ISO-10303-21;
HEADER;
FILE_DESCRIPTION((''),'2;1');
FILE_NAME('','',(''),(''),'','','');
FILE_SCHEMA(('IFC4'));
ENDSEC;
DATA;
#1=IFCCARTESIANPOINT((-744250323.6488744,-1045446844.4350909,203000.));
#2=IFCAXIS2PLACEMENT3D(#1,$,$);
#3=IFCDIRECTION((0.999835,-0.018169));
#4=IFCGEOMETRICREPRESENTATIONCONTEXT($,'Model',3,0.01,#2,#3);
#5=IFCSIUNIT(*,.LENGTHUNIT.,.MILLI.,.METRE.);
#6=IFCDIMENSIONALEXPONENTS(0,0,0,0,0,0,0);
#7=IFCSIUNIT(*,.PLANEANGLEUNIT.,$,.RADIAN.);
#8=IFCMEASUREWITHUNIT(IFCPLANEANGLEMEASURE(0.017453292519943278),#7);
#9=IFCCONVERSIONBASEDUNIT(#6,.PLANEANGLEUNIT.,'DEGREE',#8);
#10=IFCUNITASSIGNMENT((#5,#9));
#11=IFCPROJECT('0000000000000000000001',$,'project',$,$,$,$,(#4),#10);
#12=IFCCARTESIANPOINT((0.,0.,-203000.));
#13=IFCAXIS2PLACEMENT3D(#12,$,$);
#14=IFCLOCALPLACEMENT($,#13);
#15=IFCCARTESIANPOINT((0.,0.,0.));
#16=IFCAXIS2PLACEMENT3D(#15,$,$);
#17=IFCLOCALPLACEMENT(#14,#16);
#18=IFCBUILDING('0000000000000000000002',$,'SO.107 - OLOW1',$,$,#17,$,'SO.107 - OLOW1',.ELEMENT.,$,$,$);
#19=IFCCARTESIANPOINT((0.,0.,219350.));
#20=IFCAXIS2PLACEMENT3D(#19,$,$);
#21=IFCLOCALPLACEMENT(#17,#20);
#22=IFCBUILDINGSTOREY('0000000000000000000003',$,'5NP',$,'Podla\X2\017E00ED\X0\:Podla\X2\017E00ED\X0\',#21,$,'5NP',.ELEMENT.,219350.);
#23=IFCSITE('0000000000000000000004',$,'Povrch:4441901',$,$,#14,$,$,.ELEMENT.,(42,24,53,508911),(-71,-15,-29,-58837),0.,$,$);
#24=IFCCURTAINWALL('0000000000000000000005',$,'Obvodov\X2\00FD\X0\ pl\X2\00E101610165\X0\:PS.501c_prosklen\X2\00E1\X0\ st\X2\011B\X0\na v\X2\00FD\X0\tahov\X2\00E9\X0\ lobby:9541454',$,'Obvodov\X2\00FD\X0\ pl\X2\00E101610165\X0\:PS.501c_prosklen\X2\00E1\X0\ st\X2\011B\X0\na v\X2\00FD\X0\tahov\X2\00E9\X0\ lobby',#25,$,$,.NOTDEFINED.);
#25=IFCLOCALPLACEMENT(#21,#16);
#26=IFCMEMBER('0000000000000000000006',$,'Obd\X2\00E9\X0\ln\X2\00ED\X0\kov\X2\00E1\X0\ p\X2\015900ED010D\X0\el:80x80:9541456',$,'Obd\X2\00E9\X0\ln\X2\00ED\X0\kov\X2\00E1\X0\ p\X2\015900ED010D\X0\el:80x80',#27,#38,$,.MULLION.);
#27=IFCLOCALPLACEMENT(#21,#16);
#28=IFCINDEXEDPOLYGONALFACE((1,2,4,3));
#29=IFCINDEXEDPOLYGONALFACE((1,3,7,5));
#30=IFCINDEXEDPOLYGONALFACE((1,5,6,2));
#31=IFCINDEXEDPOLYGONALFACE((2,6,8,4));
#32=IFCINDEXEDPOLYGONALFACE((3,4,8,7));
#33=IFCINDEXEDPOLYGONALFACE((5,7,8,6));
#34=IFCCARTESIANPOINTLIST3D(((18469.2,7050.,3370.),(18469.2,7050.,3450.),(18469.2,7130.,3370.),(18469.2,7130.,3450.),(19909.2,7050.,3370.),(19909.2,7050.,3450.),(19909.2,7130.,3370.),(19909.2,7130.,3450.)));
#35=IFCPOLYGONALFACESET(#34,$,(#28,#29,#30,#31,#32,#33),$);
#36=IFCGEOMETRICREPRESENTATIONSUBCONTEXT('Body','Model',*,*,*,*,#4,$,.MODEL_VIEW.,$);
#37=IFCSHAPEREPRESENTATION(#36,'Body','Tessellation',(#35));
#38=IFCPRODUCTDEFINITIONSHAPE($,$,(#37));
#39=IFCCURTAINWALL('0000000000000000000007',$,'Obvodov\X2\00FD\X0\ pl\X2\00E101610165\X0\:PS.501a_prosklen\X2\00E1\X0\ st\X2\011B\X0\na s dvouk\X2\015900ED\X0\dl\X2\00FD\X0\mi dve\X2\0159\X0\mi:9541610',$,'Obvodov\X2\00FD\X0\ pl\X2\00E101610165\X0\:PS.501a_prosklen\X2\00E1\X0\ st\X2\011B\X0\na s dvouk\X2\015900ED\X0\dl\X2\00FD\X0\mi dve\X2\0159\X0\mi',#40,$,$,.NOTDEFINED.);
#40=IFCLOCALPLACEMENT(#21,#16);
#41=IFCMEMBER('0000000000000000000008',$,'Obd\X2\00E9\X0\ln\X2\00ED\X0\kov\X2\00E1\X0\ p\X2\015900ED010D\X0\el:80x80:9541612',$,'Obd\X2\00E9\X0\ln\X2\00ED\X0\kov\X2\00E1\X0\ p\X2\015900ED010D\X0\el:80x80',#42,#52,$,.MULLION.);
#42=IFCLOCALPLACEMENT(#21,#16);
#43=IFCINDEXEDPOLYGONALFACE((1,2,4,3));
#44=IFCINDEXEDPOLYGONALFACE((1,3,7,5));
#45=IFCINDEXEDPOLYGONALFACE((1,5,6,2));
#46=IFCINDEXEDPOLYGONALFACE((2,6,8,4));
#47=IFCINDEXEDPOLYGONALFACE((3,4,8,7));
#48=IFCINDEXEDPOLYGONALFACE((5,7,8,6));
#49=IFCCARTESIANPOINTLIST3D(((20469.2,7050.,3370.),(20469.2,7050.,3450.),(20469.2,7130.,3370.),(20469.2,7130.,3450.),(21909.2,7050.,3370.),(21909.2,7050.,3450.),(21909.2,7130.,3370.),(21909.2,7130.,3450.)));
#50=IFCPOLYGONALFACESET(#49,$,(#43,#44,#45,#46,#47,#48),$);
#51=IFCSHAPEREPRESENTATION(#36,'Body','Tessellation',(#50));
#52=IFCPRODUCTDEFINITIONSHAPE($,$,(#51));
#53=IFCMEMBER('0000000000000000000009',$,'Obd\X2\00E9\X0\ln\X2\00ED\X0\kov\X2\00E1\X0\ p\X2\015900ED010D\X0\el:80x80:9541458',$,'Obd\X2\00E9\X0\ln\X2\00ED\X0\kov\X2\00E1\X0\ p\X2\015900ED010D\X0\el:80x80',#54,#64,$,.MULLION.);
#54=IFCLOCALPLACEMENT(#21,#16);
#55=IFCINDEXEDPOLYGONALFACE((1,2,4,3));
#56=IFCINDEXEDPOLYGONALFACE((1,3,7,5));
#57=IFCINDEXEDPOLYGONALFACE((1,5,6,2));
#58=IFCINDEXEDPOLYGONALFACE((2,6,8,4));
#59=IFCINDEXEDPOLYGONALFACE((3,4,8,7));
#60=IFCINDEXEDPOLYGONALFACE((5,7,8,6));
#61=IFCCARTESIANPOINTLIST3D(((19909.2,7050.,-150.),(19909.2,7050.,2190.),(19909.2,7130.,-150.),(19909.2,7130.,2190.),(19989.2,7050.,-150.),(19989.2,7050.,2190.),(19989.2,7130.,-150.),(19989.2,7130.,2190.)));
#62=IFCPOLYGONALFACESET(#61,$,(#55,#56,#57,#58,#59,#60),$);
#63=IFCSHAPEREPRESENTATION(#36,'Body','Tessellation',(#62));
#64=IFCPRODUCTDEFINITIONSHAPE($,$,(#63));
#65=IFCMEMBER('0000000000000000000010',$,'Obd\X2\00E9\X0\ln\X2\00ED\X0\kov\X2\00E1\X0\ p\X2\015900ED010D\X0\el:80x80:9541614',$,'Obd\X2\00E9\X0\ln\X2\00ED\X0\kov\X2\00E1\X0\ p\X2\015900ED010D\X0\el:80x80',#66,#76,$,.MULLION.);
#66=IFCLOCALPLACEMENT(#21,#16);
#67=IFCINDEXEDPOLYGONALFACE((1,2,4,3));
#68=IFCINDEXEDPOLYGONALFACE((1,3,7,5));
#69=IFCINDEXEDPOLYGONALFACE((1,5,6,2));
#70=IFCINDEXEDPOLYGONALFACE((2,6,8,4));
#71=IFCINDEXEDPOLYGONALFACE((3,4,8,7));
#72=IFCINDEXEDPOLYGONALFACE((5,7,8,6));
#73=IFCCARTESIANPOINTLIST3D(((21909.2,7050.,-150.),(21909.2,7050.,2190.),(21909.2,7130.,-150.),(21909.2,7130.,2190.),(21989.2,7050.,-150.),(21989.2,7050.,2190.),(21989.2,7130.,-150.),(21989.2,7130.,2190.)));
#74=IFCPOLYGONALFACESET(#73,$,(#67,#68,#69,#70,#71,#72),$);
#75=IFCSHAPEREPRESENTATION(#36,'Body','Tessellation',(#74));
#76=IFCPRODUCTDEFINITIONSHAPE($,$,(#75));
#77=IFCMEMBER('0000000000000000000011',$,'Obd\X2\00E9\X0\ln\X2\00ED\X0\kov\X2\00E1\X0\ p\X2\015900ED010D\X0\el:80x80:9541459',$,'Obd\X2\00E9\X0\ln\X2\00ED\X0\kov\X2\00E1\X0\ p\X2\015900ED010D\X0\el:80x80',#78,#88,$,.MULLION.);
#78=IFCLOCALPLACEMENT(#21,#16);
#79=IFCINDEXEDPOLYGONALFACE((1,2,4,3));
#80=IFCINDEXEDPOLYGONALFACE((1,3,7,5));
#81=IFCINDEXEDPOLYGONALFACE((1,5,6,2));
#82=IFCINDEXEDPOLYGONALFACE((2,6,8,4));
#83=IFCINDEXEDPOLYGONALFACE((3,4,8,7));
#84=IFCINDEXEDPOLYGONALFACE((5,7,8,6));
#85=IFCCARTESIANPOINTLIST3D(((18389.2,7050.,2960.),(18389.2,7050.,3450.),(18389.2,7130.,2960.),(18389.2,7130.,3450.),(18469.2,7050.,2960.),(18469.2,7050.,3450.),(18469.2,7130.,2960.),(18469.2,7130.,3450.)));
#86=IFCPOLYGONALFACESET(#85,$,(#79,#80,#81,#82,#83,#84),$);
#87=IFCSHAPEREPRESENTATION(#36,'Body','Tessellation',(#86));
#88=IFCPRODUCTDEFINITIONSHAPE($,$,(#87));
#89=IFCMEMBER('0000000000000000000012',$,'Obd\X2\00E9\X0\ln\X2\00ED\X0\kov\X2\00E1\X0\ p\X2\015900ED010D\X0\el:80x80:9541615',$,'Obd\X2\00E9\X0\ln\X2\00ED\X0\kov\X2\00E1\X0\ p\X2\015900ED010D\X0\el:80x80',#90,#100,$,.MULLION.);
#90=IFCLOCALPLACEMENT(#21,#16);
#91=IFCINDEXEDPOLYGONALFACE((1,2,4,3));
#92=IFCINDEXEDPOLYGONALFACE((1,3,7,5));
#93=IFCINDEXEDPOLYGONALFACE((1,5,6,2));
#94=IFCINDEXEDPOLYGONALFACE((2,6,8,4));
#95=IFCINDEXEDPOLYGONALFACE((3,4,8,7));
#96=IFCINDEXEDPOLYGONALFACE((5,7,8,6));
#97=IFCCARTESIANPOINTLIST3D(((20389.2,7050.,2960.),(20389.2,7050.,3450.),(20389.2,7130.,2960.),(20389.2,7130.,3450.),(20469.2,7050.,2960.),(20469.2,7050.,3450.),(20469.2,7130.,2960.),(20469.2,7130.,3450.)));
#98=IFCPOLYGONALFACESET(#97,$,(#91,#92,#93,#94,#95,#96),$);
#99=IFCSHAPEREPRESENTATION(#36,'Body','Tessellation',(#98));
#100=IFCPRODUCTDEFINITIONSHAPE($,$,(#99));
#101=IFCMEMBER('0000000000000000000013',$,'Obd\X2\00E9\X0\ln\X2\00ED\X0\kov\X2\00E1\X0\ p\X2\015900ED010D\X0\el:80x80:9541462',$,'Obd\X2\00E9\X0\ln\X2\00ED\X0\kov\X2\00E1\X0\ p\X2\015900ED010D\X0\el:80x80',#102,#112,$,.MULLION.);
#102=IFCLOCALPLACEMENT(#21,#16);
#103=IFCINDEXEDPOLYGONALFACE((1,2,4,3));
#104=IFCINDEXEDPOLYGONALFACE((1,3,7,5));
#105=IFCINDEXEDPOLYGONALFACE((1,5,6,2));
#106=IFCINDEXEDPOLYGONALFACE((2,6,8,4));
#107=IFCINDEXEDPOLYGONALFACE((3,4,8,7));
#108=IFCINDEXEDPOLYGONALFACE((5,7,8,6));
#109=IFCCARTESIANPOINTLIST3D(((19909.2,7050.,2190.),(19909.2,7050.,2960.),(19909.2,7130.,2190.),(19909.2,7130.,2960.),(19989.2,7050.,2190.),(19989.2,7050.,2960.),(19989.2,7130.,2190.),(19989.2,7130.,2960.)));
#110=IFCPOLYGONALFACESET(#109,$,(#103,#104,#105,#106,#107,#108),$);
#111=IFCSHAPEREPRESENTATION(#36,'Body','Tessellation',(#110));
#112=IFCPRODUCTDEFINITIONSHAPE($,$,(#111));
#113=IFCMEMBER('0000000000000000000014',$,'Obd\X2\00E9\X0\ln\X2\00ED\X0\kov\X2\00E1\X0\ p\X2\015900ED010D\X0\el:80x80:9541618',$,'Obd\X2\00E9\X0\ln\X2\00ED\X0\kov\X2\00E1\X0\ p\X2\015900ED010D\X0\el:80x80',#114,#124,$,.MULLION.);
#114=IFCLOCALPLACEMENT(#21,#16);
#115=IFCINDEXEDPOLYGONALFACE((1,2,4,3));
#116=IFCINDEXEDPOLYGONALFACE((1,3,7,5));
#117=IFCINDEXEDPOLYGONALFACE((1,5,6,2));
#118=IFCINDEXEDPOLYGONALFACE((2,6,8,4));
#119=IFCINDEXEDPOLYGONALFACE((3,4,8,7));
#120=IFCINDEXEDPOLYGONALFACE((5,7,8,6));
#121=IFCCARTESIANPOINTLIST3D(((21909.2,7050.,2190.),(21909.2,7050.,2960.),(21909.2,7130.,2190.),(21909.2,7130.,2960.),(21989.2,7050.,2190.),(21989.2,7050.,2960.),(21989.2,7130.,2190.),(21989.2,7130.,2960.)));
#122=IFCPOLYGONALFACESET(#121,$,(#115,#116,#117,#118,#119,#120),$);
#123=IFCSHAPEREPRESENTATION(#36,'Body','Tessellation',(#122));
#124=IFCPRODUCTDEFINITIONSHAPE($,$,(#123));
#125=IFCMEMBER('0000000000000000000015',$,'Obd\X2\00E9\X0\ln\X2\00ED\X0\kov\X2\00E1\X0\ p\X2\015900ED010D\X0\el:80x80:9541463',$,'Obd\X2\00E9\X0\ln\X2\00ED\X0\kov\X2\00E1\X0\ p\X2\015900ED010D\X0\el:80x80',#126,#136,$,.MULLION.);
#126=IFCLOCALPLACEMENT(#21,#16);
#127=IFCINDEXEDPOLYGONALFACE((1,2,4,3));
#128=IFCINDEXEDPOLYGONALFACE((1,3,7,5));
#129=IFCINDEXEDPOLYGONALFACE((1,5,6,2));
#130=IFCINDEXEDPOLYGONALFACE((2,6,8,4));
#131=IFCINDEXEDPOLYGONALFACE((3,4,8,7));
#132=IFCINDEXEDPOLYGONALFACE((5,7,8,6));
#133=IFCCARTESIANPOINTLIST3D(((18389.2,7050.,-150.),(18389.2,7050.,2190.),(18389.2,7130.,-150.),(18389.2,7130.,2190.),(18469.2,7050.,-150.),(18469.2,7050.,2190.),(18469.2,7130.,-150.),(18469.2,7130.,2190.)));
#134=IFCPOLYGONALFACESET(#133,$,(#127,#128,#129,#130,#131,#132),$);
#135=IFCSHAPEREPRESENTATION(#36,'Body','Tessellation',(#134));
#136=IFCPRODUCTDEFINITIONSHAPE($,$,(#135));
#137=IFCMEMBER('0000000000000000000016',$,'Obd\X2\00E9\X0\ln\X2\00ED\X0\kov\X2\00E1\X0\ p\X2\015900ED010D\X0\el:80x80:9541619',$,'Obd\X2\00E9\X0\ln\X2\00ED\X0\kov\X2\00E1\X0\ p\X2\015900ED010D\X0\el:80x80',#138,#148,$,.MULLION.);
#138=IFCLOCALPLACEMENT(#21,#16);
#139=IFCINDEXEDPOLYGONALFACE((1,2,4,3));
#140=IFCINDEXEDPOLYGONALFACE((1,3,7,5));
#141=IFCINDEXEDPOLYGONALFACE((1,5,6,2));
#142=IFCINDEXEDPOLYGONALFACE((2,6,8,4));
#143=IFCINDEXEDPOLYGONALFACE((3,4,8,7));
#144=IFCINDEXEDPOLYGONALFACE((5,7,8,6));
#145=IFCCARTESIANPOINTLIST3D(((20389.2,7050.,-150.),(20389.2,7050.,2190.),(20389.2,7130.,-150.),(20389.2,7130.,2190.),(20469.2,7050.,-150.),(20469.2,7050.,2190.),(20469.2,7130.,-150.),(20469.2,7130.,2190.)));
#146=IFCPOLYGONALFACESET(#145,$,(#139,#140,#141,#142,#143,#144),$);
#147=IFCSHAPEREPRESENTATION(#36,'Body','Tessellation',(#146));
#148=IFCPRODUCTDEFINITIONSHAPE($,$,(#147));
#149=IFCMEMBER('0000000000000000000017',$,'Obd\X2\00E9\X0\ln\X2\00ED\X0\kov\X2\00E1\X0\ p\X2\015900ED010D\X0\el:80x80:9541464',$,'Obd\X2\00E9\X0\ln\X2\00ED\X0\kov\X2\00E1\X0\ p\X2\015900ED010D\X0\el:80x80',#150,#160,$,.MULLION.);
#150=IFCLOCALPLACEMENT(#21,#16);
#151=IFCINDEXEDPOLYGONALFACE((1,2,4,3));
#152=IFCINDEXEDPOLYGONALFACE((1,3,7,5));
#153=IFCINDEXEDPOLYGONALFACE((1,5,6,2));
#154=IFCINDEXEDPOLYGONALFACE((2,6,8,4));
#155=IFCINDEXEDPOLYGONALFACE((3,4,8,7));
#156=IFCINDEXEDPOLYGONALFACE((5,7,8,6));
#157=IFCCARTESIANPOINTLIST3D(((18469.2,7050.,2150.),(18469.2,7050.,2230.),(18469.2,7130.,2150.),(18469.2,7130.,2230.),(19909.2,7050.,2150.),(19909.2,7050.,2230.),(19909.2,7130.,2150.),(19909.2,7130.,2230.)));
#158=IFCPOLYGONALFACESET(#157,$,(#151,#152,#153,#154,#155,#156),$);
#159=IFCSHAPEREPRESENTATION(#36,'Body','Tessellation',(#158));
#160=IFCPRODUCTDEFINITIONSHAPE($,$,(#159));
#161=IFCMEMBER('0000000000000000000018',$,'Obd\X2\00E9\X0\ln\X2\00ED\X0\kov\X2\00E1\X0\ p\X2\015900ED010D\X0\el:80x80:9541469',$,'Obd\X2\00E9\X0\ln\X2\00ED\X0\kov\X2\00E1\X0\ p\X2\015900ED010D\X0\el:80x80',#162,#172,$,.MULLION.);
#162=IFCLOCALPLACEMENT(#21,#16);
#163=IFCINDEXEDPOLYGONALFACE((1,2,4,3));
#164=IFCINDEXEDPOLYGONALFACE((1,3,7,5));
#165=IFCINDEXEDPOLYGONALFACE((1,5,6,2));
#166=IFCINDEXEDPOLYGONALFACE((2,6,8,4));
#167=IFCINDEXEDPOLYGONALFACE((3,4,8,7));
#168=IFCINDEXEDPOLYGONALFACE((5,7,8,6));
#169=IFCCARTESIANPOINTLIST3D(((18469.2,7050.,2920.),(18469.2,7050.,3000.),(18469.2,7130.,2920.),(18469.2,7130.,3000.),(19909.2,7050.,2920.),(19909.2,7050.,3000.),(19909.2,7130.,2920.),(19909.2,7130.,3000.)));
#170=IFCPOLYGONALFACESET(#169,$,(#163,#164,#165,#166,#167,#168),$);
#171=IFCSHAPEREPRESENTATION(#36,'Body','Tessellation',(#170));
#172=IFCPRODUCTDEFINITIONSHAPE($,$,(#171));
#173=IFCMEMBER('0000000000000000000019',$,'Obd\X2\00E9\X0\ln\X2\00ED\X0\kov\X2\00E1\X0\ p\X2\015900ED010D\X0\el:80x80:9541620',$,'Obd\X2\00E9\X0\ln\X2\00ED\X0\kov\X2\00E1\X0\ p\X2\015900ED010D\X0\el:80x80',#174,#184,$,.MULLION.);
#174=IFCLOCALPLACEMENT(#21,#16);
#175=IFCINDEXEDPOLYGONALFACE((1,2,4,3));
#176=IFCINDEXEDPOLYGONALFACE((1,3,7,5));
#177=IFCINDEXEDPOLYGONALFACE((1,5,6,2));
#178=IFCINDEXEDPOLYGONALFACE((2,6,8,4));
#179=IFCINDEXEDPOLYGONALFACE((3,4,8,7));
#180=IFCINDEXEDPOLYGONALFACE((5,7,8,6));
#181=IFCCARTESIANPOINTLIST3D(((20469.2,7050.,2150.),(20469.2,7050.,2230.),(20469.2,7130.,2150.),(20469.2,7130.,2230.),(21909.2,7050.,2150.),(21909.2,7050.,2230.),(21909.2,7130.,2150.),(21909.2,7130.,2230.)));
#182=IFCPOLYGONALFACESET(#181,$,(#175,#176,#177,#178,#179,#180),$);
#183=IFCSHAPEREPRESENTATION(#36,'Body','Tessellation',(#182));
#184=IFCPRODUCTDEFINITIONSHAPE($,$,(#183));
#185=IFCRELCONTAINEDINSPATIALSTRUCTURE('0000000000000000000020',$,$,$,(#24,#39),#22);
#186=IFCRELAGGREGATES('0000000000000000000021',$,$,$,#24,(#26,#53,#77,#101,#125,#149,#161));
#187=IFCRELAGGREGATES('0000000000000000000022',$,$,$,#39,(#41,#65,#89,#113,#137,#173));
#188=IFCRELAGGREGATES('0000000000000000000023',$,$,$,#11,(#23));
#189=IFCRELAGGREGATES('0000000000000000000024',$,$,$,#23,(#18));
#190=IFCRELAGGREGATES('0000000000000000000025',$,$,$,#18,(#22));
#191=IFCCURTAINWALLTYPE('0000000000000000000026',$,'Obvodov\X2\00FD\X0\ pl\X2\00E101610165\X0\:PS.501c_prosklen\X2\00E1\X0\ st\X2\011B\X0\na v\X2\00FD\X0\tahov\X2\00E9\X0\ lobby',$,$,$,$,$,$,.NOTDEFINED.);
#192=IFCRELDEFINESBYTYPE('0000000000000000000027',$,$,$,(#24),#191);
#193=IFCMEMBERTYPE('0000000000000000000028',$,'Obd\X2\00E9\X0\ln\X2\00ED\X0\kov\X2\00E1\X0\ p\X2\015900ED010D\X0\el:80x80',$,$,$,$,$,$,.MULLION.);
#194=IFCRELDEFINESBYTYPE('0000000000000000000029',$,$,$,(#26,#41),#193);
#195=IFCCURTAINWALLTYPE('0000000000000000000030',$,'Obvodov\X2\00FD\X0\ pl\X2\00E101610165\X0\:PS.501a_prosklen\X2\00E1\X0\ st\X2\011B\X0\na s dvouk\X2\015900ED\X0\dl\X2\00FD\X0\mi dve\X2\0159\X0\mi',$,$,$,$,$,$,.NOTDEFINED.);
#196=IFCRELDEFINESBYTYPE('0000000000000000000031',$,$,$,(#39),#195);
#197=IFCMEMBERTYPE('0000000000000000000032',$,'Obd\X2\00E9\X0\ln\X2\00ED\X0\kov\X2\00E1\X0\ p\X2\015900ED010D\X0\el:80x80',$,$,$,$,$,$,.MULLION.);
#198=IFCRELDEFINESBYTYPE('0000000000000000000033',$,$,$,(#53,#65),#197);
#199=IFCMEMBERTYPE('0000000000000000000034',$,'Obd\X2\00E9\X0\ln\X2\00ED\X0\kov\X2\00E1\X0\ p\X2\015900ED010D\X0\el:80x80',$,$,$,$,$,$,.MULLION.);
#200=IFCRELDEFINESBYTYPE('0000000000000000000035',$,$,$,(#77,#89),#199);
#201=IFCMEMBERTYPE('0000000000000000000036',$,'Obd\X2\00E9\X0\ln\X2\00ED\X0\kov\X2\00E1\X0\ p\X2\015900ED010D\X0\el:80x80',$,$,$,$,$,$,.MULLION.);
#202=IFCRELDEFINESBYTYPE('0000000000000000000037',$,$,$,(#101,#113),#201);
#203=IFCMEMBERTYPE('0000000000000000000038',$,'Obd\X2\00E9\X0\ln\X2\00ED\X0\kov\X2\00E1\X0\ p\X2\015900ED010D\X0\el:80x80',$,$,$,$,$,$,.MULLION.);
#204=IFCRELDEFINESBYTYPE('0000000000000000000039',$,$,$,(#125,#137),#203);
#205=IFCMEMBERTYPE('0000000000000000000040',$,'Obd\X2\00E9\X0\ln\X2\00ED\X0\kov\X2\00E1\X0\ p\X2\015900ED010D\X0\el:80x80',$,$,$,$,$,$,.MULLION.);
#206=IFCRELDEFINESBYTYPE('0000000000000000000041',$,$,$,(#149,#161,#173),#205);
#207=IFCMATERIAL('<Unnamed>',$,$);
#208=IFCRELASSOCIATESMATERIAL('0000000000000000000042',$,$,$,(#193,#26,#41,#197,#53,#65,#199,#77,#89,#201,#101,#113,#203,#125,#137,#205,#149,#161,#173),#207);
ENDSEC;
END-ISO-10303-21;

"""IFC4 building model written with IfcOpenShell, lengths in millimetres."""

from ifc_helpers import new_model, entity, si_unit, converted_unit, direction, frame, origin, place, context, subcontext, project, spatial, indexed_curve, outline, extrude, source, transform, mapped, material, type_object, type_shapes, element, aggregate, save


model = new_model("IFC4")

# Units and contexts
model_context = context("Model", 3, precision=0.01, world=frame((-744250323.6488744, -1045446844.4350909, 203000.0)), true_north=direction((0.999835, -0.018169)))
body_context = subcontext(model_context, "Body", "Model", "MODEL_VIEW")
ifc_project = project(units=[si_unit("LENGTHUNIT", "METRE", prefix="MILLI"), converted_unit("PLANEANGLEUNIT", "DEGREE", entity("IfcPlaneAngleMeasure", 0.017453292519943278), si_unit("PLANEANGLEUNIT", "RADIAN"), dimensions=[0, 0, 0, 0, 0, 0, 0])], contexts=[model_context])

# Site, building, storey
site_placement = place(None, frame((0.0, 0.0, -203000.0)))
site = spatial("IfcSite", under=ifc_project, at=site_placement, Name="Povrch:4441901", CompositionType="ELEMENT", RefLatitude=(42, 24, 53, 508911), RefLongitude=(-71, -15, -29, -58837), RefElevation=0.0)
building_placement = place(site_placement, origin())
building = spatial("IfcBuilding", under=site, at=building_placement, Name="SO.107 - OLOW1", LongName="SO.107 - OLOW1", CompositionType="ELEMENT")
storey_placement = place(building_placement, frame((0.0, 0.0, 219350.0)))
storey = spatial("IfcBuildingStorey", under=building, at=storey_placement, Name="5NP", ObjectType="Podlaží:Podlaží", LongName="5NP", CompositionType="ELEMENT", Elevation=219350.0)

# Curtain walls, members
curtain_wall_type_1 = type_object("IfcCurtainWallType", Name="Obvodový plášť:PS.501c_prosklená stěna výtahové lobby", PredefinedType="NOTDEFINED")
curtain_wall_1_placement = place(storey_placement, frame((0.0, 0.0, -219350.0)))
curtain_wall_1 = element("IfcCurtainWall", 1, at=curtain_wall_1_placement, inside=storey, type_object=curtain_wall_type_1, Name="Obvodový plášť:PS.501c_prosklená stěna výtahové lobby:9541454", ObjectType="Obvodový plášť:PS.501c_prosklená stěna výtahové lobby", PredefinedType="NOTDEFINED")
ifc_material_1 = material(Name="<Unnamed>")
member_type_1 = type_object("IfcMemberType", Name="Obdélníková příčel:80x80", PredefinedType="MULLION", material=ifc_material_1)
shared_shape_1 = source(origin(), body_context, "Body", "SweptSolid", [
    extrude(outline(indexed_curve([(-40.0, -40.0), (40.0, -40.0), (40.0, 40.0), (-40.0, 40.0), (-40.0, -40.0)], self_intersect=False)), frame((-40.0, 0.0, -1440.0), z_axis=(0.0, 0.0, 1.0), x_axis=(-1.0, 0.0, 0.0)), (0.0, 0.0, 1.0), 1440.0),
])
type_shapes(member_type_1, [shared_shape_1])
member_1_placement = place(curtain_wall_1_placement, frame((19909.2, 7090.0, 222800.0), z_axis=(1.0, 0.0, 0.0), x_axis=(0.0, 0.0, 1.0)))
member_1 = element("IfcMember", 2, at=member_1_placement, type_object=member_type_1, material=ifc_material_1, Name="Obdélníková příčel:80x80:9541456", ObjectType="Obdélníková příčel:80x80", PredefinedType="MULLION", context=body_context, shape_type="MappedRepresentation", body=[
    mapped(shared_shape_1, transform((0.0, 0.0, 0.0), scale=1.0)),
])
curtain_wall_type_2 = type_object("IfcCurtainWallType", Name="Obvodový plášť:PS.501a_prosklená stěna s dvoukřídlými dveřmi", PredefinedType="NOTDEFINED")
curtain_wall_2_placement = place(storey_placement, frame((0.0, 0.0, -219350.0)))
curtain_wall_2 = element("IfcCurtainWall", 3, at=curtain_wall_2_placement, inside=storey, type_object=curtain_wall_type_2, Name="Obvodový plášť:PS.501a_prosklená stěna s dvoukřídlými dveřmi:9541610", ObjectType="Obvodový plášť:PS.501a_prosklená stěna s dvoukřídlými dveřmi", PredefinedType="NOTDEFINED")
member_2_placement = place(curtain_wall_2_placement, frame((21909.2, 7090.0, 222800.0), z_axis=(1.0, 0.0, 0.0), x_axis=(0.0, 0.0, 1.0)))
member_2 = element("IfcMember", 4, at=member_2_placement, type_object=member_type_1, material=ifc_material_1, Name="Obdélníková příčel:80x80:9541612", ObjectType="Obdélníková příčel:80x80", PredefinedType="MULLION", context=body_context, shape_type="MappedRepresentation", body=[
    mapped(shared_shape_1, transform((0.0, 0.0, 0.0), scale=1.0)),
])

# Members
member_type_2 = type_object("IfcMemberType", Name="Obdélníková příčel:80x80", PredefinedType="MULLION", material=ifc_material_1)
shared_shape_2 = source(origin(), body_context, "Body", "SweptSolid", [
    extrude(outline(indexed_curve([(-40.0, -40.0), (40.0, -40.0), (40.0, 40.0), (-40.0, 40.0), (-40.0, -40.0)], self_intersect=False)), frame((-40.0, 0.0, -2340.0), z_axis=(0.0, 0.0, 1.0), x_axis=(-1.0, 0.0, 0.0)), (0.0, 0.0, 1.0), 2340.0),
])
type_shapes(member_type_2, [shared_shape_2])
member_3_placement = place(curtain_wall_1_placement, frame((19989.2, 7090.0, 219200.0), z_axis=(0.0, 0.0, -1.0), x_axis=(1.0, 0.0, 0.0)))
member_3 = element("IfcMember", 5, at=member_3_placement, type_object=member_type_2, material=ifc_material_1, Name="Obdélníková příčel:80x80:9541458", ObjectType="Obdélníková příčel:80x80", PredefinedType="MULLION", context=body_context, shape_type="MappedRepresentation", body=[
    mapped(shared_shape_2, transform((0.0, 0.0, 0.0), scale=1.0)),
])
member_4_placement = place(curtain_wall_2_placement, frame((21989.2, 7090.0, 219200.0), z_axis=(0.0, 0.0, -1.0), x_axis=(1.0, 0.0, 0.0)))
member_4 = element("IfcMember", 6, at=member_4_placement, type_object=member_type_2, material=ifc_material_1, Name="Obdélníková příčel:80x80:9541614", ObjectType="Obdélníková příčel:80x80", PredefinedType="MULLION", context=body_context, shape_type="MappedRepresentation", body=[
    mapped(shared_shape_2, transform((0.0, 0.0, 0.0), scale=1.0)),
])
member_type_3 = type_object("IfcMemberType", Name="Obdélníková příčel:80x80", PredefinedType="MULLION", material=ifc_material_1)
shared_shape_3 = source(origin(), body_context, "Body", "SweptSolid", [
    extrude(outline(indexed_curve([(-40.0, -40.0), (40.0, -40.0), (40.0, 40.0), (-40.0, 40.0), (-40.0, -40.0)], self_intersect=False)), frame((-40.0, 0.0, -490.0), z_axis=(0.0, 0.0, 1.0), x_axis=(-1.0, 0.0, 0.0)), (0.0, 0.0, 1.0), 490.0),
])
type_shapes(member_type_3, [shared_shape_3])
member_5_placement = place(curtain_wall_1_placement, frame((18389.2, 7090.0, 222800.0), z_axis=(0.0, 0.0, 1.0), x_axis=(-1.0, 0.0, 0.0)))
member_5 = element("IfcMember", 7, at=member_5_placement, type_object=member_type_3, material=ifc_material_1, Name="Obdélníková příčel:80x80:9541459", ObjectType="Obdélníková příčel:80x80", PredefinedType="MULLION", context=body_context, shape_type="MappedRepresentation", body=[
    mapped(shared_shape_3, transform((0.0, 0.0, 0.0), scale=1.0)),
])
member_6_placement = place(curtain_wall_2_placement, frame((20389.2, 7090.0, 222800.0), z_axis=(0.0, 0.0, 1.0), x_axis=(-1.0, 0.0, 0.0)))
member_6 = element("IfcMember", 8, at=member_6_placement, type_object=member_type_3, material=ifc_material_1, Name="Obdélníková příčel:80x80:9541615", ObjectType="Obdélníková příčel:80x80", PredefinedType="MULLION", context=body_context, shape_type="MappedRepresentation", body=[
    mapped(shared_shape_3, transform((0.0, 0.0, 0.0), scale=1.0)),
])
member_type_4 = type_object("IfcMemberType", Name="Obdélníková příčel:80x80", PredefinedType="MULLION", material=ifc_material_1)
shared_shape_4 = source(origin(), body_context, "Body", "SweptSolid", [
    extrude(outline(indexed_curve([(-40.0, -40.0), (40.0, -40.0), (40.0, 40.0), (-40.0, 40.0), (-40.0, -40.0)], self_intersect=False)), frame((-40.0, 0.0, -770.0), z_axis=(0.0, 0.0, 1.0), x_axis=(-1.0, 0.0, 0.0)), (0.0, 0.0, 1.0), 770.0),
])
type_shapes(member_type_4, [shared_shape_4])
member_7_placement = place(curtain_wall_1_placement, frame((19989.2, 7090.0, 221540.0), z_axis=(0.0, 0.0, -1.0), x_axis=(1.0, 0.0, 0.0)))
member_7 = element("IfcMember", 9, at=member_7_placement, type_object=member_type_4, material=ifc_material_1, Name="Obdélníková příčel:80x80:9541462", ObjectType="Obdélníková příčel:80x80", PredefinedType="MULLION", context=body_context, shape_type="MappedRepresentation", body=[
    mapped(shared_shape_4, transform((0.0, 0.0, 0.0), scale=1.0)),
])
member_8_placement = place(curtain_wall_2_placement, frame((21989.2, 7090.0, 221540.0), z_axis=(0.0, 0.0, -1.0), x_axis=(1.0, 0.0, 0.0)))
member_8 = element("IfcMember", 10, at=member_8_placement, type_object=member_type_4, material=ifc_material_1, Name="Obdélníková příčel:80x80:9541618", ObjectType="Obdélníková příčel:80x80", PredefinedType="MULLION", context=body_context, shape_type="MappedRepresentation", body=[
    mapped(shared_shape_4, transform((0.0, 0.0, 0.0), scale=1.0)),
])
member_type_5 = type_object("IfcMemberType", Name="Obdélníková příčel:80x80", PredefinedType="MULLION", material=ifc_material_1)
shared_shape_5 = source(origin(), body_context, "Body", "SweptSolid", [
    extrude(outline(indexed_curve([(-40.0, -40.0), (40.0, -40.0), (40.0, 40.0), (-40.0, 40.0), (-40.0, -40.0)], self_intersect=False)), frame((-40.0, 0.0, -2340.0), z_axis=(0.0, 0.0, 1.0), x_axis=(-1.0, 0.0, 0.0)), (0.0, 0.0, 1.0), 2340.0),
])
type_shapes(member_type_5, [shared_shape_5])
member_9_placement = place(curtain_wall_1_placement, frame((18389.2, 7090.0, 221540.0), z_axis=(0.0, 0.0, 1.0), x_axis=(-1.0, 0.0, 0.0)))
member_9 = element("IfcMember", 11, at=member_9_placement, type_object=member_type_5, material=ifc_material_1, Name="Obdélníková příčel:80x80:9541463", ObjectType="Obdélníková příčel:80x80", PredefinedType="MULLION", context=body_context, shape_type="MappedRepresentation", body=[
    mapped(shared_shape_5, transform((0.0, 0.0, 0.0), scale=1.0)),
])
member_10_placement = place(curtain_wall_2_placement, frame((20389.2, 7090.0, 221540.0), z_axis=(0.0, 0.0, 1.0), x_axis=(-1.0, 0.0, 0.0)))
member_10 = element("IfcMember", 12, at=member_10_placement, type_object=member_type_5, material=ifc_material_1, Name="Obdélníková příčel:80x80:9541619", ObjectType="Obdélníková příčel:80x80", PredefinedType="MULLION", context=body_context, shape_type="MappedRepresentation", body=[
    mapped(shared_shape_5, transform((0.0, 0.0, 0.0), scale=1.0)),
])
member_type_6 = type_object("IfcMemberType", Name="Obdélníková příčel:80x80", PredefinedType="MULLION", material=ifc_material_1)
shared_shape_6 = source(origin(), body_context, "Body", "SweptSolid", [
    extrude(outline(indexed_curve([(-40.0, -40.0), (40.0, -40.0), (40.0, 40.0), (-40.0, 40.0), (-40.0, -40.0)], self_intersect=False)), frame((0.0, 0.0, -1440.0), z_axis=(0.0, 0.0, 1.0), x_axis=(-1.0, 0.0, 0.0)), (0.0, 0.0, 1.0), 1440.0),
])
type_shapes(member_type_6, [shared_shape_6])
member_11_placement = place(curtain_wall_1_placement, frame((19909.2, 7090.0, 221540.0), z_axis=(1.0, 0.0, 0.0), x_axis=(0.0, 0.0, 1.0)))
member_11 = element("IfcMember", 13, at=member_11_placement, type_object=member_type_6, material=ifc_material_1, Name="Obdélníková příčel:80x80:9541464", ObjectType="Obdélníková příčel:80x80", PredefinedType="MULLION", context=body_context, shape_type="MappedRepresentation", body=[
    mapped(shared_shape_6, transform((0.0, 0.0, 0.0), scale=1.0)),
])
member_12_placement = place(curtain_wall_1_placement, frame((19909.2, 7090.0, 222310.0), z_axis=(1.0, 0.0, 0.0), x_axis=(0.0, 0.0, 1.0)))
member_12 = element("IfcMember", 14, at=member_12_placement, type_object=member_type_6, material=ifc_material_1, Name="Obdélníková příčel:80x80:9541469", ObjectType="Obdélníková příčel:80x80", PredefinedType="MULLION", context=body_context, shape_type="MappedRepresentation", body=[
    mapped(shared_shape_6, transform((0.0, 0.0, 0.0), scale=1.0)),
])
member_13_placement = place(curtain_wall_2_placement, frame((21909.2, 7090.0, 221540.0), z_axis=(1.0, 0.0, 0.0), x_axis=(0.0, 0.0, 1.0)))
member_13 = element("IfcMember", 15, at=member_13_placement, type_object=member_type_6, material=ifc_material_1, Name="Obdélníková příčel:80x80:9541620", ObjectType="Obdélníková příčel:80x80", PredefinedType="MULLION", context=body_context, shape_type="MappedRepresentation", body=[
    mapped(shared_shape_6, transform((0.0, 0.0, 0.0), scale=1.0)),
])

aggregate(curtain_wall_1, [member_1, member_3, member_5, member_7, member_9, member_11, member_12])

aggregate(curtain_wall_2, [member_2, member_4, member_6, member_8, member_10, member_13])

save(model, "model.ifc")
